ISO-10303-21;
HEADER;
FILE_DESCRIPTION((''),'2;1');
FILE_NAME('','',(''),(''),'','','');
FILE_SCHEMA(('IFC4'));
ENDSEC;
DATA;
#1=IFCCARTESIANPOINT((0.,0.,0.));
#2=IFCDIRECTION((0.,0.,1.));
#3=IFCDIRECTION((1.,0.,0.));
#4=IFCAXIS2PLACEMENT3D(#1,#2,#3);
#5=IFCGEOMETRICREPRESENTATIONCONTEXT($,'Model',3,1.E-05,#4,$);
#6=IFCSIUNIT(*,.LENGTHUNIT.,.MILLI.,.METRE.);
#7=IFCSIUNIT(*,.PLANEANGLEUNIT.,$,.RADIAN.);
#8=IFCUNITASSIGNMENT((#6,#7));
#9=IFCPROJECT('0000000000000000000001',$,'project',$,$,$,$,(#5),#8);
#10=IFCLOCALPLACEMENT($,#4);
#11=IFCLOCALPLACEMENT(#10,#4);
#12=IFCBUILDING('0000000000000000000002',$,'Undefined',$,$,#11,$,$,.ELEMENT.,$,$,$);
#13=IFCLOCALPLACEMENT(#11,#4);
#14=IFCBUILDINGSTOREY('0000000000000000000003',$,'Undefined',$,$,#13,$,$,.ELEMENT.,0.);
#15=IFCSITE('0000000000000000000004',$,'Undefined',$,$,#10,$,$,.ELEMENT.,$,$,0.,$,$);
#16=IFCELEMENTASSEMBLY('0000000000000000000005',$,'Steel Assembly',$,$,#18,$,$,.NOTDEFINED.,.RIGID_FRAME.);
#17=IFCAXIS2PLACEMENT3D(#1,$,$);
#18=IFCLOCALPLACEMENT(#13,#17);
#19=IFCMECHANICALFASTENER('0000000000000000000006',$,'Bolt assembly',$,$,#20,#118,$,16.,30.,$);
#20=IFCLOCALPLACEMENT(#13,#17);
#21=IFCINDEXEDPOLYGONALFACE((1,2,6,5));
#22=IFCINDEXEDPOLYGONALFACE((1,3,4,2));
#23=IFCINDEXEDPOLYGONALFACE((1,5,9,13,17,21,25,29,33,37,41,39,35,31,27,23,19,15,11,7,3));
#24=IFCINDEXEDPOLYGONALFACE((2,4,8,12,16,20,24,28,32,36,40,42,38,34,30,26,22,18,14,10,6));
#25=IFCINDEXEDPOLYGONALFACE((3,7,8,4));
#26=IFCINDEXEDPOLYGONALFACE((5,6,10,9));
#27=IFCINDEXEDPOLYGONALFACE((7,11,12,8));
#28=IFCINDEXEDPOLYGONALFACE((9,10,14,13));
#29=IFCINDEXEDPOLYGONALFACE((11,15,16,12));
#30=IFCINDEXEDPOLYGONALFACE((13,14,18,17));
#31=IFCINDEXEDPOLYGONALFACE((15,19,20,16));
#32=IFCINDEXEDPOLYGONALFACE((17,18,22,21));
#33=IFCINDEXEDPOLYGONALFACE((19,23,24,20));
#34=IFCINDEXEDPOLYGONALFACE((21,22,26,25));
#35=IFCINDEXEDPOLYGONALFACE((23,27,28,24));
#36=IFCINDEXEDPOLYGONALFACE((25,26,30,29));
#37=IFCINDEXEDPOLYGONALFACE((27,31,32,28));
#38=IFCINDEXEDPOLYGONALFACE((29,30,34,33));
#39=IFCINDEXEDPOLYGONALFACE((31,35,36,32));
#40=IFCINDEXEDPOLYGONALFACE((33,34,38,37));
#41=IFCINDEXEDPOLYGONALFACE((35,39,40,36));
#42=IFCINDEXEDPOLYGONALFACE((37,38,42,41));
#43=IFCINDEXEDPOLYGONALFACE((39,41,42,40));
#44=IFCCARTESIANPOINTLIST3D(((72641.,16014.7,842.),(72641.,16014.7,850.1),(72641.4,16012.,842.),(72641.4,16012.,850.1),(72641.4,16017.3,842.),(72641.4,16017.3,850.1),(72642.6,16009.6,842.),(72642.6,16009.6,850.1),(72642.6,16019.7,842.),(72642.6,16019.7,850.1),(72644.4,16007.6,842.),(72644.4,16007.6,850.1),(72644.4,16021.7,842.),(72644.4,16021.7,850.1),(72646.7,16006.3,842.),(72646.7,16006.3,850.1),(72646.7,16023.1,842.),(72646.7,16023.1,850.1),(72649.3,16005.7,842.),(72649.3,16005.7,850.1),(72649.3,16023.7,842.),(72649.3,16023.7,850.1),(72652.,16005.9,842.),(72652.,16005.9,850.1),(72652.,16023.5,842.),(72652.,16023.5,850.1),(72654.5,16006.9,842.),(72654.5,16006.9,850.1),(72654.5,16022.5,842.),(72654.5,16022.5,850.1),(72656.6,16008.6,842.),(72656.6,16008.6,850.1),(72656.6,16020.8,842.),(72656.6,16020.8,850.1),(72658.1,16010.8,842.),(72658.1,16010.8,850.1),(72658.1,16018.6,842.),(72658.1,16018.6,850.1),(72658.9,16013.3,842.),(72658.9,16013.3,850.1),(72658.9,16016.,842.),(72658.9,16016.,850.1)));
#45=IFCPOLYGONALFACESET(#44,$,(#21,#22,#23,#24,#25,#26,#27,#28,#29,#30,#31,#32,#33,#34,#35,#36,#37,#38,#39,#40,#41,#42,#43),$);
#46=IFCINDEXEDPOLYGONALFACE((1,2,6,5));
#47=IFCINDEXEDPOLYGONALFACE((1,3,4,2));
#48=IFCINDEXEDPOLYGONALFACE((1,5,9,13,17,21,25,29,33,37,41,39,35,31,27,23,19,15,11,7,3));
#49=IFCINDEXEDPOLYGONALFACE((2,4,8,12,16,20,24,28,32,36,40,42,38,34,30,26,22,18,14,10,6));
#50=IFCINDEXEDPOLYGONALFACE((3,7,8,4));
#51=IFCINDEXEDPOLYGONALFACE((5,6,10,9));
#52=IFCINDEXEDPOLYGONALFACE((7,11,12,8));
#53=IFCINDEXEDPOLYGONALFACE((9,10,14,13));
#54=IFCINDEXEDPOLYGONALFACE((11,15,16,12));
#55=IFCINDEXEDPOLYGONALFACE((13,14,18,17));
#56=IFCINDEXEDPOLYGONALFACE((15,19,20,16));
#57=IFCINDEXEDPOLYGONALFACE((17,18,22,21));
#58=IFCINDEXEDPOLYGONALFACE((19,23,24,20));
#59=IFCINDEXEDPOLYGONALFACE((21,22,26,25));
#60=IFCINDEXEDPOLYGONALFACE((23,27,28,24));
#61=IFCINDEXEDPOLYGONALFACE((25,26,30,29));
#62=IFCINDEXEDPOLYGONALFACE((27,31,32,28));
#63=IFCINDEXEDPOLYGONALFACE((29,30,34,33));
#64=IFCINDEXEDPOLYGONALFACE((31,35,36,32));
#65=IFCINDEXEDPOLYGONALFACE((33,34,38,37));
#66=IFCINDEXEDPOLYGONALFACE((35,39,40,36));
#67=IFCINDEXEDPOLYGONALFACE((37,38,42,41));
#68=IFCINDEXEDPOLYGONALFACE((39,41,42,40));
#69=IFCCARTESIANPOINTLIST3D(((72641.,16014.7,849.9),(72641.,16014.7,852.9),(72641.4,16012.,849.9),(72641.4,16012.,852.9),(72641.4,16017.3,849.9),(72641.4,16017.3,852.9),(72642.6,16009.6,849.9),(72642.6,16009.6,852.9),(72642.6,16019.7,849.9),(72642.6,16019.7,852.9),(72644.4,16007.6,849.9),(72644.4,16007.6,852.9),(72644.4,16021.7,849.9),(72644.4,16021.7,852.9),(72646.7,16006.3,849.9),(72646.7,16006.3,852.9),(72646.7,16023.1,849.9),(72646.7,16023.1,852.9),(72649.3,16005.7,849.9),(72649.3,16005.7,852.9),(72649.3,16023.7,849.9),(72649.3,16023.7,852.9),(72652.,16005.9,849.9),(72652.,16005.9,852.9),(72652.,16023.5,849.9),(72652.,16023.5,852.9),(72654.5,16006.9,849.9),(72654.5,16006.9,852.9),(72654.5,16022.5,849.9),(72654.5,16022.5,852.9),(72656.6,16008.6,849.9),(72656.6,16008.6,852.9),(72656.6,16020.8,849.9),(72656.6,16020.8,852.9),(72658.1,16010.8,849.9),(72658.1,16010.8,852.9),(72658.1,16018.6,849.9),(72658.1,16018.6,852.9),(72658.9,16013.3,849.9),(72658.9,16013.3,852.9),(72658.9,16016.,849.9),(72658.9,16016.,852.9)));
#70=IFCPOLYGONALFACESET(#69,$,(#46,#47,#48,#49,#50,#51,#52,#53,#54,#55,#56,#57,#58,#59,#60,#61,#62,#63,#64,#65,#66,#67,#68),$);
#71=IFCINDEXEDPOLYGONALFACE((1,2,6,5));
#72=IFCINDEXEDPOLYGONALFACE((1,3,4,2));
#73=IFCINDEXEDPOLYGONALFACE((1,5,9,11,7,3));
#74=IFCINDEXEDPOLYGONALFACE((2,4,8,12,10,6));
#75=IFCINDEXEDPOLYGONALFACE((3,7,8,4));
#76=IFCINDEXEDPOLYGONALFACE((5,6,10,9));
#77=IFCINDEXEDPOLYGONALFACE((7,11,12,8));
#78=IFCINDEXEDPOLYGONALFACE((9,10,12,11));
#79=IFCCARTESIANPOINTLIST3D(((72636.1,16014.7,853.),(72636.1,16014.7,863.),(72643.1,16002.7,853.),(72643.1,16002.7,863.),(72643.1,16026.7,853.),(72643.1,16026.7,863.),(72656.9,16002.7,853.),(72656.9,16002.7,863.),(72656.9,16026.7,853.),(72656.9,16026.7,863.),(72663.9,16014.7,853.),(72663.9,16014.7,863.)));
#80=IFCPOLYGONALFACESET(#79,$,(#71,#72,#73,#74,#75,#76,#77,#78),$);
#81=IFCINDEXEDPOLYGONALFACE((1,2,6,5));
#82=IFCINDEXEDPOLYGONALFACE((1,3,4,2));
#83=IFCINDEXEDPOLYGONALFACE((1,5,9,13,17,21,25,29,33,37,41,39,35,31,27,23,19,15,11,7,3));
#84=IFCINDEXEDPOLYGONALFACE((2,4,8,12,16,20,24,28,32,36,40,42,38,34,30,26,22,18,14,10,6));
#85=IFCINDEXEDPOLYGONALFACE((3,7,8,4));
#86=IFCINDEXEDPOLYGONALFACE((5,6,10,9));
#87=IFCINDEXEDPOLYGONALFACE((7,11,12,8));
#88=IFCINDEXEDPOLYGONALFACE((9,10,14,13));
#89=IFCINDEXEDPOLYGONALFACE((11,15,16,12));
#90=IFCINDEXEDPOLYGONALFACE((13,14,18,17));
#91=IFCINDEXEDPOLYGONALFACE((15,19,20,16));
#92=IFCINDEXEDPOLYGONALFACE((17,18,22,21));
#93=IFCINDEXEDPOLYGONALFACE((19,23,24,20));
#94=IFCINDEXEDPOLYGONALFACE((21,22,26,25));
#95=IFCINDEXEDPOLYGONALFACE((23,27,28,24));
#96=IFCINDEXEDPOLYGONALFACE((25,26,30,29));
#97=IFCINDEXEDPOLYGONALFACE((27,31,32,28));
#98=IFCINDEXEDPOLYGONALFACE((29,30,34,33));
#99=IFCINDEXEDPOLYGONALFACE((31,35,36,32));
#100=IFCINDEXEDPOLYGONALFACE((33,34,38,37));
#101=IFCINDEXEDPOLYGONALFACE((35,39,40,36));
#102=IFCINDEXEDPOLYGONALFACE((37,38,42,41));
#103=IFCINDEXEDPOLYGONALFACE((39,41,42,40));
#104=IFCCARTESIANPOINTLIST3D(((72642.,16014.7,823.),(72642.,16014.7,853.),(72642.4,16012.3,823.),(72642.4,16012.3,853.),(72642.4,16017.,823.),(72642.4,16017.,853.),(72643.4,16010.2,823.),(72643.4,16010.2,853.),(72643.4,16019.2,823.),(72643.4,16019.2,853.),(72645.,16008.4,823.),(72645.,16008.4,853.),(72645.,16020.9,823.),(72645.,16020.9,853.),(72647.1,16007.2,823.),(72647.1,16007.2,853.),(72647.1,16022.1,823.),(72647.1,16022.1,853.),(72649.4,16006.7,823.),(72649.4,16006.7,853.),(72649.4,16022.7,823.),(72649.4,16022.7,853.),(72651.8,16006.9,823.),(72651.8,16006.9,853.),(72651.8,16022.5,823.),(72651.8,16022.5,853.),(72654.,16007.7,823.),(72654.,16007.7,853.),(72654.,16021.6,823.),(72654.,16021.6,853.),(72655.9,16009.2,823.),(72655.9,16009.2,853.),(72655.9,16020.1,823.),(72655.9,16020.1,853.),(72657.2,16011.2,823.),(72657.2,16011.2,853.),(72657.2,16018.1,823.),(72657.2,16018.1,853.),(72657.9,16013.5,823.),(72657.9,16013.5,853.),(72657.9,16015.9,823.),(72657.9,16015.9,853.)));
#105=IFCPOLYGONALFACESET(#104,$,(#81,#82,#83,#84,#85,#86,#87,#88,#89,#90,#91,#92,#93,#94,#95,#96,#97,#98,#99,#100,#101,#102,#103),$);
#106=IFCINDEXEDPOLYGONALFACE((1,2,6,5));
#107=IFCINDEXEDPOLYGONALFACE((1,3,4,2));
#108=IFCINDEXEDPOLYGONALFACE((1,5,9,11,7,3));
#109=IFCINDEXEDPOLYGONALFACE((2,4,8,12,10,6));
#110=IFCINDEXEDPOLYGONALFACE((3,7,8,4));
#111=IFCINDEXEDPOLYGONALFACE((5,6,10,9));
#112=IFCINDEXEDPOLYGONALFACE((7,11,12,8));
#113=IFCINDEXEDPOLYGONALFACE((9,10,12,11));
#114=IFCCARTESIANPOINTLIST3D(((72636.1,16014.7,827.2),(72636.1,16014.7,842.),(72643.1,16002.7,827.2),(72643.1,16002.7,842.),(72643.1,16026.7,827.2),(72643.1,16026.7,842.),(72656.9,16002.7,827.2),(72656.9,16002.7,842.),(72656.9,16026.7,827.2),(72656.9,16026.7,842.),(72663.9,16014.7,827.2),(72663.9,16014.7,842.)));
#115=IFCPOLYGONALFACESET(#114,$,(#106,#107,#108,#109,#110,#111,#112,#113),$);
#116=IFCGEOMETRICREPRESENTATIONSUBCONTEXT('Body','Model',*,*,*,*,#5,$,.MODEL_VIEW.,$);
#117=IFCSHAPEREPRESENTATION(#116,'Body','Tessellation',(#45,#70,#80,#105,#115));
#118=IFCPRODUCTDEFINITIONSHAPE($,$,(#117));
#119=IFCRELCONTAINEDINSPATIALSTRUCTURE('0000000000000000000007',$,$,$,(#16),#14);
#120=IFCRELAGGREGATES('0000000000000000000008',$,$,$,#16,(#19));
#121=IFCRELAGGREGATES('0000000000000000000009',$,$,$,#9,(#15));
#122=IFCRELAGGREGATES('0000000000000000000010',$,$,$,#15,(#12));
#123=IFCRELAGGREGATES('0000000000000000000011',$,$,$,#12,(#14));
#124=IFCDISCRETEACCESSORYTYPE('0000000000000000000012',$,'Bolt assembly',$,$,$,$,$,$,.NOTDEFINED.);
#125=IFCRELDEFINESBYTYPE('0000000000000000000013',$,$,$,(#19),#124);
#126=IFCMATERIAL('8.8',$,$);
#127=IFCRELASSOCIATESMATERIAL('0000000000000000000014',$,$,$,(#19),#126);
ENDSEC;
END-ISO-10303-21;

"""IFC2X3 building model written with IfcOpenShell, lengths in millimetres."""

from ifc_helpers import new_model, si_unit, frame, origin_with_axes, origin_2d_with_axis, place, context, subcontext, project, spatial, polyline, circle, outline, extrude, source, transform, mapped, material, type_object, element, aggregate, save


model = new_model("IFC2X3")

# Units and contexts
model_context = context("Model", 3, precision=1e-05, world=origin_with_axes())
body_context = subcontext(model_context, "Body", "Model", "MODEL_VIEW")
ifc_project = project(units=[si_unit("LENGTHUNIT", "METRE", prefix="MILLI"), si_unit("PLANEANGLEUNIT", "RADIAN")], contexts=[model_context])

# Site, building, storey
site_placement = place(None, origin_with_axes())
site = spatial("IfcSite", under=ifc_project, at=site_placement, Name="Undefined", CompositionType="ELEMENT", RefElevation=0.0)
building_placement = place(site_placement, origin_with_axes())
building = spatial("IfcBuilding", under=site, at=building_placement, Name="Undefined", CompositionType="ELEMENT")
storey_placement = place(building_placement, origin_with_axes())
storey = spatial("IfcBuildingStorey", under=building, at=storey_placement, Name="Undefined", CompositionType="ELEMENT", Elevation=0.0)

# Element assembly
assembly_1_placement = place(storey_placement, origin_with_axes())
assembly_1 = element("IfcElementAssembly", 1, at=assembly_1_placement, inside=storey, Name="Steel Assembly", AssemblyPlace="NOTDEFINED", PredefinedType="RIGID_FRAME")

# Shared definitions
discrete_accessory_type_1 = type_object("IfcDiscreteAccessoryType", Name="Bolt assembly")
ifc_material_1 = material(Name="8.8")

# Mechanical fastener
shared_shape_1 = source(origin_with_axes(), body_context, "Body", "SweptSolid", [
    extrude(circle(Radius=9.0, at=origin_2d_with_axis()), frame((0.0, -0.1, 0.0), z_axis=(0.0, 1.0, 0.0), x_axis=(1.0, 0.0, 0.0)), (0.0, 0.0, 1.0), 8.1),
    extrude(circle(Radius=9.0, at=origin_2d_with_axis()), frame((0.0, -2.9, 0.0), z_axis=(0.0, 1.0, 0.0), x_axis=(1.0, 0.0, 0.0)), (0.0, 0.0, 1.0), 3.0),
    extrude(outline(polyline([(13.9, 0.0), (6.9, 12.0), (-6.9, 12.0), (-13.9, 0.0), (-6.9, -12.0), (6.9, -12.0), (13.9, 0.0)])), frame((0.0, -13.0, 0.0), z_axis=(0.0, 1.0, 0.0), x_axis=(1.0, 0.0, 0.0)), (0.0, 0.0, 1.0), 10.0),
    extrude(circle(Radius=8.0, at=origin_2d_with_axis()), frame((0.0, -3.0, 0.0), z_axis=(0.0, 1.0, 0.0), x_axis=(1.0, 0.0, 0.0)), (0.0, 0.0, 1.0), 30.0),
    extrude(outline(polyline([(13.9, 0.0), (6.9, 12.0), (-6.9, 12.0), (-13.9, 0.0), (-6.9, -12.0), (6.9, -12.0), (13.9, 0.0)])), frame((0.0, 8.0, 0.0), z_axis=(0.0, 1.0, 0.0), x_axis=(1.0, 0.0, 0.0)), (0.0, 0.0, 1.0), 14.8),
])
mechanical_fastener_1_placement = place(assembly_1_placement, frame((72650.0, 16014.7, 850.0), z_axis=(0.0, -1.0, 0.0), x_axis=(-1.0, 0.0, 0.0)))
mechanical_fastener_1 = element("IfcMechanicalFastener", 2, at=mechanical_fastener_1_placement, type_object=discrete_accessory_type_1, material=ifc_material_1, Name="Bolt assembly", NominalDiameter=16.0, NominalLength=30.0, context=body_context, shape_type="MappedRepresentation", body=[
    mapped(shared_shape_1, transform((0.0, 0.0, 0.0))),
])
aggregate(assembly_1, [mechanical_fastener_1])

save(model, "model.ifc")
